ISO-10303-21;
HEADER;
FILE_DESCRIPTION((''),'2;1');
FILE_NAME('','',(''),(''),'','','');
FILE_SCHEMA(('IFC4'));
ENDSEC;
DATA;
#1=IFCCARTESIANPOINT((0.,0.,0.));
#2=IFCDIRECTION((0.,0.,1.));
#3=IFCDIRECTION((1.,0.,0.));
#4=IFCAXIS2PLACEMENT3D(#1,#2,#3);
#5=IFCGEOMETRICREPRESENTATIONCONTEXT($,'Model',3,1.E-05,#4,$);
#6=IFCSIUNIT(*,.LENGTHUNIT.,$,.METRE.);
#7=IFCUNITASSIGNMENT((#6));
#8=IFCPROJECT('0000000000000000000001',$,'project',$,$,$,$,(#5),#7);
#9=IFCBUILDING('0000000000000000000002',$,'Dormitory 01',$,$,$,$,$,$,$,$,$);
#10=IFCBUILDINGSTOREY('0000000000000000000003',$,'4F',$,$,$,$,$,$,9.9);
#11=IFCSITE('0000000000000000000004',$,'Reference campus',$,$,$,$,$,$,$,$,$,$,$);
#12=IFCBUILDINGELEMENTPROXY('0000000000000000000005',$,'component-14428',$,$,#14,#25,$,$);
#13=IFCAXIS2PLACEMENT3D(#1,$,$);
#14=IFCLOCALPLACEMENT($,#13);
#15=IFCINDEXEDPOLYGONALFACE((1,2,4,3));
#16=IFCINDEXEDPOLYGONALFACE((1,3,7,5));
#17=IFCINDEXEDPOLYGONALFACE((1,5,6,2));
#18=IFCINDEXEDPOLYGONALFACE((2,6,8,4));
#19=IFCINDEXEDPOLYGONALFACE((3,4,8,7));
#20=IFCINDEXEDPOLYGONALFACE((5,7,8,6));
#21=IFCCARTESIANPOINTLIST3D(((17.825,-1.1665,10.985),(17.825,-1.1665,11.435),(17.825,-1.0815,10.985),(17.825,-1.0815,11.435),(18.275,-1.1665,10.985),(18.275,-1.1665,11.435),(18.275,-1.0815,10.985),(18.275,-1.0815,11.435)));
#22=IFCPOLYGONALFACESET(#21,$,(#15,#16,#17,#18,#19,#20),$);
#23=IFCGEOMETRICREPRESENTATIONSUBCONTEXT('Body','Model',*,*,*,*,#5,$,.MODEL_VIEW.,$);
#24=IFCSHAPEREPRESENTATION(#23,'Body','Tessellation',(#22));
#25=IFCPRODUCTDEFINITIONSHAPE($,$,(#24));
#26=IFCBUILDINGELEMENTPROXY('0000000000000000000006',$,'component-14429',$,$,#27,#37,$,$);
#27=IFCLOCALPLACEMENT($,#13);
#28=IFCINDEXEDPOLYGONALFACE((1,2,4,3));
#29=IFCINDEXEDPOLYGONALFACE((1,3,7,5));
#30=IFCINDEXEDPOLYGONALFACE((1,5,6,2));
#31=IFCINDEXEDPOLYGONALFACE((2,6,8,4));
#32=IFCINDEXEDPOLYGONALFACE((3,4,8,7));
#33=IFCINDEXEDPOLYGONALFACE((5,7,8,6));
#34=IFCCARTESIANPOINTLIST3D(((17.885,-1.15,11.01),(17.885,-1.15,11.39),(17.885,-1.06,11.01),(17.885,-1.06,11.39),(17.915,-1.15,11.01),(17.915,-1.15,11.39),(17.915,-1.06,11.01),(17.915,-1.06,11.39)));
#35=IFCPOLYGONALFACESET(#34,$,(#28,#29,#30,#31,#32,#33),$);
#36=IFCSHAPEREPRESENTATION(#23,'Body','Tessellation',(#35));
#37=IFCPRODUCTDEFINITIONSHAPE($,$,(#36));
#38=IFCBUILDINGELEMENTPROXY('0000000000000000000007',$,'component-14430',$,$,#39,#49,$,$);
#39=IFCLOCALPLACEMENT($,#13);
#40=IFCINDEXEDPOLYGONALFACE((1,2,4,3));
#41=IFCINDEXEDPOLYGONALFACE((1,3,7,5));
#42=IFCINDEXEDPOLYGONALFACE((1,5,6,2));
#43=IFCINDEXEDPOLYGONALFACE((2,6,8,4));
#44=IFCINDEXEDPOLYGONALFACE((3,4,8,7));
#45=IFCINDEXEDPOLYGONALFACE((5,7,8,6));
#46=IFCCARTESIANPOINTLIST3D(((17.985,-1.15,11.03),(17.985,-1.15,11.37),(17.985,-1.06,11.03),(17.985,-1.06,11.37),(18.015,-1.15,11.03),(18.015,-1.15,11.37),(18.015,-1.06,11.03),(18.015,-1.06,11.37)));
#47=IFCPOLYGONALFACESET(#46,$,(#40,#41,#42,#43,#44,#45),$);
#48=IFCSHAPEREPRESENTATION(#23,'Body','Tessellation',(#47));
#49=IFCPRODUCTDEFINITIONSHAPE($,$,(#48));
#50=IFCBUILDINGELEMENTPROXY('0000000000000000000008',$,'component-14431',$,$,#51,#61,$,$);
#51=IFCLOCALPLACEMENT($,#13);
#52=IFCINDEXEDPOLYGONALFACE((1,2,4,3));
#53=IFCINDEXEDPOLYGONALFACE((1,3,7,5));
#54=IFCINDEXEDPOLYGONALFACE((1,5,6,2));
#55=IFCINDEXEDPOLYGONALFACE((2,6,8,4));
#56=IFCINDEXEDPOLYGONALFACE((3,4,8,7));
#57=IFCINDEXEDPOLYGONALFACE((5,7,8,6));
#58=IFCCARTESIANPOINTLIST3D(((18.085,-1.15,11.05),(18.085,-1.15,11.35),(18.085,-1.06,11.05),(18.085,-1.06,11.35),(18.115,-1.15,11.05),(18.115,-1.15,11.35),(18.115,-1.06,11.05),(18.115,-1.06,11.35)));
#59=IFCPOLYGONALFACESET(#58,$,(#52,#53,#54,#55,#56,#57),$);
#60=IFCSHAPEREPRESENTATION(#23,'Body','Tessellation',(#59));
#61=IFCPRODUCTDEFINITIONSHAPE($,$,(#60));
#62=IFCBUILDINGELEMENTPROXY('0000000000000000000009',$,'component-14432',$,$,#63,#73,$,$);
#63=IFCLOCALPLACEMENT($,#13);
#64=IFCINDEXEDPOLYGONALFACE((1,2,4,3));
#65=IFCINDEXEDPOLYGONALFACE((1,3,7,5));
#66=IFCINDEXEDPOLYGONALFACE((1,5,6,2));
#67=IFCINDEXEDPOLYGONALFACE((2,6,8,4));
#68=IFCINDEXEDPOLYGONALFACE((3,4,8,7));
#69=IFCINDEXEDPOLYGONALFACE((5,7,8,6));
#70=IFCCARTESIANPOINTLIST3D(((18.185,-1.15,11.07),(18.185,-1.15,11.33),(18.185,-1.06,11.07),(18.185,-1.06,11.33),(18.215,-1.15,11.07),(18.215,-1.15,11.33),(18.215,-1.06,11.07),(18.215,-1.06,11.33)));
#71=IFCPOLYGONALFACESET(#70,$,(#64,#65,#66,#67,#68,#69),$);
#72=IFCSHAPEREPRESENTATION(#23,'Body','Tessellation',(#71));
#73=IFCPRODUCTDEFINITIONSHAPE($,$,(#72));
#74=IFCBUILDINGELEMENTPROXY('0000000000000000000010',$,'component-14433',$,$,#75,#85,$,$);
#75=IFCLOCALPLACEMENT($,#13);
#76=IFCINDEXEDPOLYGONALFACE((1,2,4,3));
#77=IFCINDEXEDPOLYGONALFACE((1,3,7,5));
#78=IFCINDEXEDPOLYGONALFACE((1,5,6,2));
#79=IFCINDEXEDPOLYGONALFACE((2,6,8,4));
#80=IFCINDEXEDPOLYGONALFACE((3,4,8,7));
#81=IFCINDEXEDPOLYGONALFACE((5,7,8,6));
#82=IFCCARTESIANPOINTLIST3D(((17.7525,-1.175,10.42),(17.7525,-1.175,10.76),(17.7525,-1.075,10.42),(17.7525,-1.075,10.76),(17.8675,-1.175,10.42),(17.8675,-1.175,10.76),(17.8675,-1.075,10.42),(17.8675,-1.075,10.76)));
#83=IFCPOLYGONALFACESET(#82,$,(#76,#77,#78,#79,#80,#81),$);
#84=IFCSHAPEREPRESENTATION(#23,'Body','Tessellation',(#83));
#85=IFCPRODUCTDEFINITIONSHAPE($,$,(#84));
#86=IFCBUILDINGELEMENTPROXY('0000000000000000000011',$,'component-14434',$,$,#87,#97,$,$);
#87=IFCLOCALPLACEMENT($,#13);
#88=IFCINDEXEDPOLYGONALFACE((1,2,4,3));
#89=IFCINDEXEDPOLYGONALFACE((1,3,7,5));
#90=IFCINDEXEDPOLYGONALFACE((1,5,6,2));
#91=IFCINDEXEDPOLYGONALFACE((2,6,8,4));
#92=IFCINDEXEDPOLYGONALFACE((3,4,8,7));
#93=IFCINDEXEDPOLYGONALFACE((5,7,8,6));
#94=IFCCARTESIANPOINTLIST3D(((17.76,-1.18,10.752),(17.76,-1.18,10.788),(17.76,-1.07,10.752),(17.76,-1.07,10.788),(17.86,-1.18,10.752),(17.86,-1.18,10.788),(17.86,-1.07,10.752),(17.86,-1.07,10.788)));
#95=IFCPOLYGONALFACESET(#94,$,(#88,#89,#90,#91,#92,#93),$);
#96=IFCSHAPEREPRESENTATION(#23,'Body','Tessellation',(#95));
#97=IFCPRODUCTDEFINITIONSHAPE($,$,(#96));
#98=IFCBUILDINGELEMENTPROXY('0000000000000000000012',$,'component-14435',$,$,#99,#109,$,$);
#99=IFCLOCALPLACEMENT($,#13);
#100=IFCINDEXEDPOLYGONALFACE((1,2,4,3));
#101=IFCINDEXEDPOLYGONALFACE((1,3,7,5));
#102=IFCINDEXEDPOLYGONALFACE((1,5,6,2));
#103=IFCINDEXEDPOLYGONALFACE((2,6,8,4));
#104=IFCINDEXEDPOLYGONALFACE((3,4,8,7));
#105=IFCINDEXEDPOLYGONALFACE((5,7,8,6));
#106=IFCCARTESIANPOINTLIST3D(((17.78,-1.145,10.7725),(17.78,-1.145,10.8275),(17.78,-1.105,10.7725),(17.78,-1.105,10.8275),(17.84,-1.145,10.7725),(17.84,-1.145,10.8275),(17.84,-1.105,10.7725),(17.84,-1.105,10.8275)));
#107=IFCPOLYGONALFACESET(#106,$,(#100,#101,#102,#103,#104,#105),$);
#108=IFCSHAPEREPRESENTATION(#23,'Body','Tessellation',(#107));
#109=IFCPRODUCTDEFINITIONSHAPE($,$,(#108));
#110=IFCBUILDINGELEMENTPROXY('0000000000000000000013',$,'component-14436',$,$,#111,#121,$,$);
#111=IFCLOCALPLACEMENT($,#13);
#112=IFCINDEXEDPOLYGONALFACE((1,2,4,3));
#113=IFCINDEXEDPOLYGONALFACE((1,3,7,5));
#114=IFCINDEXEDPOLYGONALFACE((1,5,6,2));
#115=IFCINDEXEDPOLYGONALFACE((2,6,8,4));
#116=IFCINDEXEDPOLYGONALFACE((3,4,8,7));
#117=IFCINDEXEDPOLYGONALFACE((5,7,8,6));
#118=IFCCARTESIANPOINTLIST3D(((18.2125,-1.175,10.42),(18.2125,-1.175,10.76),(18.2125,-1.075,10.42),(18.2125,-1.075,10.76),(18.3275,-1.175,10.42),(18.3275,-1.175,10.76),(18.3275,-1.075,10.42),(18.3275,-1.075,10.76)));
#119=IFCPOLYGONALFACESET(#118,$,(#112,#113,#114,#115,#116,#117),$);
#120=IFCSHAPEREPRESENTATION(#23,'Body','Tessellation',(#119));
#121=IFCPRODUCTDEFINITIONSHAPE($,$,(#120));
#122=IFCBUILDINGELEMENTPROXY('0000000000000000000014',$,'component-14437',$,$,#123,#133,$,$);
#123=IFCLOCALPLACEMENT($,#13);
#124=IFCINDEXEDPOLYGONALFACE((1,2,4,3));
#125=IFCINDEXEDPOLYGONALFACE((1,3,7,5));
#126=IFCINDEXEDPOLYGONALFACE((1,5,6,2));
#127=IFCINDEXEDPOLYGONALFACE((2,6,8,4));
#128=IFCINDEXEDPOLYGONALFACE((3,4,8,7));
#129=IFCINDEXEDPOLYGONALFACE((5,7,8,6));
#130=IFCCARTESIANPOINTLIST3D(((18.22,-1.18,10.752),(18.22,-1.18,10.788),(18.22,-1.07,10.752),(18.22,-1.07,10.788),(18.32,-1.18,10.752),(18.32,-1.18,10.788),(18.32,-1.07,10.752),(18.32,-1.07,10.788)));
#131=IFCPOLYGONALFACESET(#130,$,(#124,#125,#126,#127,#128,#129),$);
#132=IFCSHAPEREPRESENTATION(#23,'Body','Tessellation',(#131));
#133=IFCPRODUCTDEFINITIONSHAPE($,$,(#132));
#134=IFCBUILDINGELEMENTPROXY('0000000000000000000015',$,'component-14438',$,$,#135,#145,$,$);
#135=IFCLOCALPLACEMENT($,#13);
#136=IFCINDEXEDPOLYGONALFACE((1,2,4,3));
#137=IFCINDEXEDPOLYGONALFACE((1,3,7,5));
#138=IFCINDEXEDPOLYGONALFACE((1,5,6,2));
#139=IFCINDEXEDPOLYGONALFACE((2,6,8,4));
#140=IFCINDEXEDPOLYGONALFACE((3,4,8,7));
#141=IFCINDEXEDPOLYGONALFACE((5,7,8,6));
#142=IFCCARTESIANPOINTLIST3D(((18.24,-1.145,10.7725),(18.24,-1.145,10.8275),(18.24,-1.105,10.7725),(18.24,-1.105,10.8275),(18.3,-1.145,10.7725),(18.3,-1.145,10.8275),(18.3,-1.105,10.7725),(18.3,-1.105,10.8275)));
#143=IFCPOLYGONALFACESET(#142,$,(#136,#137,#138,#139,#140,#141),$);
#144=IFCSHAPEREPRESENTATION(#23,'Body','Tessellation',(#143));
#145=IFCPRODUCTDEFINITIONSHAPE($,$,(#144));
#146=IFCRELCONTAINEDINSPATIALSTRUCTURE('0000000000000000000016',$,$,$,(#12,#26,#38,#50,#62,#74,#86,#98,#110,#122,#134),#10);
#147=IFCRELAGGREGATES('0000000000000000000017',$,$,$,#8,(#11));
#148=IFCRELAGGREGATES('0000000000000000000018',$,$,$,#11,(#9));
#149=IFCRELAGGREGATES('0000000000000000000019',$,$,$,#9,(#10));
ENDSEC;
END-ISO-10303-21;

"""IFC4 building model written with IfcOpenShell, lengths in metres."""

from ifc_helpers import new_model, si_unit, frame, origin, origin_with_axes, origin_2d, place, context, subcontext, project, spatial, rectangle, extrude, element, save


model = new_model("IFC4")

# Units and contexts
model_context = context("Model", 3, precision=1e-05, world=origin_with_axes())
body_context = subcontext(model_context, "Body", "Model", "MODEL_VIEW")
ifc_project = project(units=[si_unit("LENGTHUNIT", "METRE")], contexts=[model_context])

# Site, building, storey
site = spatial("IfcSite", under=ifc_project, Name="Reference campus")
building = spatial("IfcBuilding", under=site, Name="Dormitory 01")
storey = spatial("IfcBuildingStorey", under=building, Name="4F", Elevation=9.9)

# Building element proxies
proxy_1_placement = place(None, frame((18.05, -1.124, 10.985), z_axis=(0.0, 0.0, 1.0), x_axis=(1.0, 0.0, 0.0)))
element("IfcBuildingElementProxy", 1, at=proxy_1_placement, inside=storey, Name="component-14428", context=body_context, shape_type="SweptSolid", body=[
    extrude(rectangle(XDim=0.45, YDim=0.085, at=origin_2d()), origin(), (0.0, 0.0, 1.0), 0.45),
])
proxy_2_placement = place(None, frame((17.9, -1.105, 11.01), z_axis=(0.0, 0.0, 1.0), x_axis=(1.0, 0.0, 0.0)))
element("IfcBuildingElementProxy", 2, at=proxy_2_placement, inside=storey, Name="component-14429", context=body_context, shape_type="SweptSolid", body=[
    extrude(rectangle(XDim=0.03, YDim=0.09, at=origin_2d()), origin(), (0.0, 0.0, 1.0), 0.38),
])
proxy_3_placement = place(None, frame((18.0, -1.105, 11.03), z_axis=(0.0, 0.0, 1.0), x_axis=(1.0, 0.0, 0.0)))
element("IfcBuildingElementProxy", 3, at=proxy_3_placement, inside=storey, Name="component-14430", context=body_context, shape_type="SweptSolid", body=[
    extrude(rectangle(XDim=0.03, YDim=0.09, at=origin_2d()), origin(), (0.0, 0.0, 1.0), 0.34),
])
proxy_4_placement = place(None, frame((18.1, -1.105, 11.05), z_axis=(0.0, 0.0, 1.0), x_axis=(1.0, 0.0, 0.0)))
element("IfcBuildingElementProxy", 4, at=proxy_4_placement, inside=storey, Name="component-14431", context=body_context, shape_type="SweptSolid", body=[
    extrude(rectangle(XDim=0.03, YDim=0.09, at=origin_2d()), origin(), (0.0, 0.0, 1.0), 0.3),
])
proxy_5_placement = place(None, frame((18.2, -1.105, 11.07), z_axis=(0.0, 0.0, 1.0), x_axis=(1.0, 0.0, 0.0)))
element("IfcBuildingElementProxy", 5, at=proxy_5_placement, inside=storey, Name="component-14432", context=body_context, shape_type="SweptSolid", body=[
    extrude(rectangle(XDim=0.03, YDim=0.09, at=origin_2d()), origin(), (0.0, 0.0, 1.0), 0.26),
])
proxy_6_placement = place(None, frame((17.81, -1.125, 10.42), z_axis=(0.0, 0.0, 1.0), x_axis=(1.0, 0.0, 0.0)))
element("IfcBuildingElementProxy", 6, at=proxy_6_placement, inside=storey, Name="component-14433", context=body_context, shape_type="SweptSolid", body=[
    extrude(rectangle(XDim=0.115, YDim=0.1, at=origin_2d()), origin(), (0.0, 0.0, 1.0), 0.34),
])
proxy_7_placement = place(None, frame((17.81, -1.125, 10.752), z_axis=(0.0, 0.0, 1.0), x_axis=(1.0, 0.0, 0.0)))
element("IfcBuildingElementProxy", 7, at=proxy_7_placement, inside=storey, Name="component-14434", context=body_context, shape_type="SweptSolid", body=[
    extrude(rectangle(XDim=0.1, YDim=0.11, at=origin_2d()), origin(), (0.0, 0.0, 1.0), 0.036),
])
proxy_8_placement = place(None, frame((17.81, -1.125, 10.7725), z_axis=(0.0, 0.0, 1.0), x_axis=(1.0, 0.0, 0.0)))
element("IfcBuildingElementProxy", 8, at=proxy_8_placement, inside=storey, Name="component-14435", context=body_context, shape_type="SweptSolid", body=[
    extrude(rectangle(XDim=0.06, YDim=0.04, at=origin_2d()), origin(), (0.0, 0.0, 1.0), 0.055),
])
proxy_9_placement = place(None, frame((18.27, -1.125, 10.42), z_axis=(0.0, 0.0, 1.0), x_axis=(1.0, 0.0, 0.0)))
element("IfcBuildingElementProxy", 9, at=proxy_9_placement, inside=storey, Name="component-14436", context=body_context, shape_type="SweptSolid", body=[
    extrude(rectangle(XDim=0.115, YDim=0.1, at=origin_2d()), origin(), (0.0, 0.0, 1.0), 0.34),
])
proxy_10_placement = place(None, frame((18.27, -1.125, 10.752), z_axis=(0.0, 0.0, 1.0), x_axis=(1.0, 0.0, 0.0)))
element("IfcBuildingElementProxy", 10, at=proxy_10_placement, inside=storey, Name="component-14437", context=body_context, shape_type="SweptSolid", body=[
    extrude(rectangle(XDim=0.1, YDim=0.11, at=origin_2d()), origin(), (0.0, 0.0, 1.0), 0.036),
])
proxy_11_placement = place(None, frame((18.27, -1.125, 10.7725), z_axis=(0.0, 0.0, 1.0), x_axis=(1.0, 0.0, 0.0)))
element("IfcBuildingElementProxy", 11, at=proxy_11_placement, inside=storey, Name="component-14438", context=body_context, shape_type="SweptSolid", body=[
    extrude(rectangle(XDim=0.06, YDim=0.04, at=origin_2d()), origin(), (0.0, 0.0, 1.0), 0.055),
])

save(model, "model.ifc")
